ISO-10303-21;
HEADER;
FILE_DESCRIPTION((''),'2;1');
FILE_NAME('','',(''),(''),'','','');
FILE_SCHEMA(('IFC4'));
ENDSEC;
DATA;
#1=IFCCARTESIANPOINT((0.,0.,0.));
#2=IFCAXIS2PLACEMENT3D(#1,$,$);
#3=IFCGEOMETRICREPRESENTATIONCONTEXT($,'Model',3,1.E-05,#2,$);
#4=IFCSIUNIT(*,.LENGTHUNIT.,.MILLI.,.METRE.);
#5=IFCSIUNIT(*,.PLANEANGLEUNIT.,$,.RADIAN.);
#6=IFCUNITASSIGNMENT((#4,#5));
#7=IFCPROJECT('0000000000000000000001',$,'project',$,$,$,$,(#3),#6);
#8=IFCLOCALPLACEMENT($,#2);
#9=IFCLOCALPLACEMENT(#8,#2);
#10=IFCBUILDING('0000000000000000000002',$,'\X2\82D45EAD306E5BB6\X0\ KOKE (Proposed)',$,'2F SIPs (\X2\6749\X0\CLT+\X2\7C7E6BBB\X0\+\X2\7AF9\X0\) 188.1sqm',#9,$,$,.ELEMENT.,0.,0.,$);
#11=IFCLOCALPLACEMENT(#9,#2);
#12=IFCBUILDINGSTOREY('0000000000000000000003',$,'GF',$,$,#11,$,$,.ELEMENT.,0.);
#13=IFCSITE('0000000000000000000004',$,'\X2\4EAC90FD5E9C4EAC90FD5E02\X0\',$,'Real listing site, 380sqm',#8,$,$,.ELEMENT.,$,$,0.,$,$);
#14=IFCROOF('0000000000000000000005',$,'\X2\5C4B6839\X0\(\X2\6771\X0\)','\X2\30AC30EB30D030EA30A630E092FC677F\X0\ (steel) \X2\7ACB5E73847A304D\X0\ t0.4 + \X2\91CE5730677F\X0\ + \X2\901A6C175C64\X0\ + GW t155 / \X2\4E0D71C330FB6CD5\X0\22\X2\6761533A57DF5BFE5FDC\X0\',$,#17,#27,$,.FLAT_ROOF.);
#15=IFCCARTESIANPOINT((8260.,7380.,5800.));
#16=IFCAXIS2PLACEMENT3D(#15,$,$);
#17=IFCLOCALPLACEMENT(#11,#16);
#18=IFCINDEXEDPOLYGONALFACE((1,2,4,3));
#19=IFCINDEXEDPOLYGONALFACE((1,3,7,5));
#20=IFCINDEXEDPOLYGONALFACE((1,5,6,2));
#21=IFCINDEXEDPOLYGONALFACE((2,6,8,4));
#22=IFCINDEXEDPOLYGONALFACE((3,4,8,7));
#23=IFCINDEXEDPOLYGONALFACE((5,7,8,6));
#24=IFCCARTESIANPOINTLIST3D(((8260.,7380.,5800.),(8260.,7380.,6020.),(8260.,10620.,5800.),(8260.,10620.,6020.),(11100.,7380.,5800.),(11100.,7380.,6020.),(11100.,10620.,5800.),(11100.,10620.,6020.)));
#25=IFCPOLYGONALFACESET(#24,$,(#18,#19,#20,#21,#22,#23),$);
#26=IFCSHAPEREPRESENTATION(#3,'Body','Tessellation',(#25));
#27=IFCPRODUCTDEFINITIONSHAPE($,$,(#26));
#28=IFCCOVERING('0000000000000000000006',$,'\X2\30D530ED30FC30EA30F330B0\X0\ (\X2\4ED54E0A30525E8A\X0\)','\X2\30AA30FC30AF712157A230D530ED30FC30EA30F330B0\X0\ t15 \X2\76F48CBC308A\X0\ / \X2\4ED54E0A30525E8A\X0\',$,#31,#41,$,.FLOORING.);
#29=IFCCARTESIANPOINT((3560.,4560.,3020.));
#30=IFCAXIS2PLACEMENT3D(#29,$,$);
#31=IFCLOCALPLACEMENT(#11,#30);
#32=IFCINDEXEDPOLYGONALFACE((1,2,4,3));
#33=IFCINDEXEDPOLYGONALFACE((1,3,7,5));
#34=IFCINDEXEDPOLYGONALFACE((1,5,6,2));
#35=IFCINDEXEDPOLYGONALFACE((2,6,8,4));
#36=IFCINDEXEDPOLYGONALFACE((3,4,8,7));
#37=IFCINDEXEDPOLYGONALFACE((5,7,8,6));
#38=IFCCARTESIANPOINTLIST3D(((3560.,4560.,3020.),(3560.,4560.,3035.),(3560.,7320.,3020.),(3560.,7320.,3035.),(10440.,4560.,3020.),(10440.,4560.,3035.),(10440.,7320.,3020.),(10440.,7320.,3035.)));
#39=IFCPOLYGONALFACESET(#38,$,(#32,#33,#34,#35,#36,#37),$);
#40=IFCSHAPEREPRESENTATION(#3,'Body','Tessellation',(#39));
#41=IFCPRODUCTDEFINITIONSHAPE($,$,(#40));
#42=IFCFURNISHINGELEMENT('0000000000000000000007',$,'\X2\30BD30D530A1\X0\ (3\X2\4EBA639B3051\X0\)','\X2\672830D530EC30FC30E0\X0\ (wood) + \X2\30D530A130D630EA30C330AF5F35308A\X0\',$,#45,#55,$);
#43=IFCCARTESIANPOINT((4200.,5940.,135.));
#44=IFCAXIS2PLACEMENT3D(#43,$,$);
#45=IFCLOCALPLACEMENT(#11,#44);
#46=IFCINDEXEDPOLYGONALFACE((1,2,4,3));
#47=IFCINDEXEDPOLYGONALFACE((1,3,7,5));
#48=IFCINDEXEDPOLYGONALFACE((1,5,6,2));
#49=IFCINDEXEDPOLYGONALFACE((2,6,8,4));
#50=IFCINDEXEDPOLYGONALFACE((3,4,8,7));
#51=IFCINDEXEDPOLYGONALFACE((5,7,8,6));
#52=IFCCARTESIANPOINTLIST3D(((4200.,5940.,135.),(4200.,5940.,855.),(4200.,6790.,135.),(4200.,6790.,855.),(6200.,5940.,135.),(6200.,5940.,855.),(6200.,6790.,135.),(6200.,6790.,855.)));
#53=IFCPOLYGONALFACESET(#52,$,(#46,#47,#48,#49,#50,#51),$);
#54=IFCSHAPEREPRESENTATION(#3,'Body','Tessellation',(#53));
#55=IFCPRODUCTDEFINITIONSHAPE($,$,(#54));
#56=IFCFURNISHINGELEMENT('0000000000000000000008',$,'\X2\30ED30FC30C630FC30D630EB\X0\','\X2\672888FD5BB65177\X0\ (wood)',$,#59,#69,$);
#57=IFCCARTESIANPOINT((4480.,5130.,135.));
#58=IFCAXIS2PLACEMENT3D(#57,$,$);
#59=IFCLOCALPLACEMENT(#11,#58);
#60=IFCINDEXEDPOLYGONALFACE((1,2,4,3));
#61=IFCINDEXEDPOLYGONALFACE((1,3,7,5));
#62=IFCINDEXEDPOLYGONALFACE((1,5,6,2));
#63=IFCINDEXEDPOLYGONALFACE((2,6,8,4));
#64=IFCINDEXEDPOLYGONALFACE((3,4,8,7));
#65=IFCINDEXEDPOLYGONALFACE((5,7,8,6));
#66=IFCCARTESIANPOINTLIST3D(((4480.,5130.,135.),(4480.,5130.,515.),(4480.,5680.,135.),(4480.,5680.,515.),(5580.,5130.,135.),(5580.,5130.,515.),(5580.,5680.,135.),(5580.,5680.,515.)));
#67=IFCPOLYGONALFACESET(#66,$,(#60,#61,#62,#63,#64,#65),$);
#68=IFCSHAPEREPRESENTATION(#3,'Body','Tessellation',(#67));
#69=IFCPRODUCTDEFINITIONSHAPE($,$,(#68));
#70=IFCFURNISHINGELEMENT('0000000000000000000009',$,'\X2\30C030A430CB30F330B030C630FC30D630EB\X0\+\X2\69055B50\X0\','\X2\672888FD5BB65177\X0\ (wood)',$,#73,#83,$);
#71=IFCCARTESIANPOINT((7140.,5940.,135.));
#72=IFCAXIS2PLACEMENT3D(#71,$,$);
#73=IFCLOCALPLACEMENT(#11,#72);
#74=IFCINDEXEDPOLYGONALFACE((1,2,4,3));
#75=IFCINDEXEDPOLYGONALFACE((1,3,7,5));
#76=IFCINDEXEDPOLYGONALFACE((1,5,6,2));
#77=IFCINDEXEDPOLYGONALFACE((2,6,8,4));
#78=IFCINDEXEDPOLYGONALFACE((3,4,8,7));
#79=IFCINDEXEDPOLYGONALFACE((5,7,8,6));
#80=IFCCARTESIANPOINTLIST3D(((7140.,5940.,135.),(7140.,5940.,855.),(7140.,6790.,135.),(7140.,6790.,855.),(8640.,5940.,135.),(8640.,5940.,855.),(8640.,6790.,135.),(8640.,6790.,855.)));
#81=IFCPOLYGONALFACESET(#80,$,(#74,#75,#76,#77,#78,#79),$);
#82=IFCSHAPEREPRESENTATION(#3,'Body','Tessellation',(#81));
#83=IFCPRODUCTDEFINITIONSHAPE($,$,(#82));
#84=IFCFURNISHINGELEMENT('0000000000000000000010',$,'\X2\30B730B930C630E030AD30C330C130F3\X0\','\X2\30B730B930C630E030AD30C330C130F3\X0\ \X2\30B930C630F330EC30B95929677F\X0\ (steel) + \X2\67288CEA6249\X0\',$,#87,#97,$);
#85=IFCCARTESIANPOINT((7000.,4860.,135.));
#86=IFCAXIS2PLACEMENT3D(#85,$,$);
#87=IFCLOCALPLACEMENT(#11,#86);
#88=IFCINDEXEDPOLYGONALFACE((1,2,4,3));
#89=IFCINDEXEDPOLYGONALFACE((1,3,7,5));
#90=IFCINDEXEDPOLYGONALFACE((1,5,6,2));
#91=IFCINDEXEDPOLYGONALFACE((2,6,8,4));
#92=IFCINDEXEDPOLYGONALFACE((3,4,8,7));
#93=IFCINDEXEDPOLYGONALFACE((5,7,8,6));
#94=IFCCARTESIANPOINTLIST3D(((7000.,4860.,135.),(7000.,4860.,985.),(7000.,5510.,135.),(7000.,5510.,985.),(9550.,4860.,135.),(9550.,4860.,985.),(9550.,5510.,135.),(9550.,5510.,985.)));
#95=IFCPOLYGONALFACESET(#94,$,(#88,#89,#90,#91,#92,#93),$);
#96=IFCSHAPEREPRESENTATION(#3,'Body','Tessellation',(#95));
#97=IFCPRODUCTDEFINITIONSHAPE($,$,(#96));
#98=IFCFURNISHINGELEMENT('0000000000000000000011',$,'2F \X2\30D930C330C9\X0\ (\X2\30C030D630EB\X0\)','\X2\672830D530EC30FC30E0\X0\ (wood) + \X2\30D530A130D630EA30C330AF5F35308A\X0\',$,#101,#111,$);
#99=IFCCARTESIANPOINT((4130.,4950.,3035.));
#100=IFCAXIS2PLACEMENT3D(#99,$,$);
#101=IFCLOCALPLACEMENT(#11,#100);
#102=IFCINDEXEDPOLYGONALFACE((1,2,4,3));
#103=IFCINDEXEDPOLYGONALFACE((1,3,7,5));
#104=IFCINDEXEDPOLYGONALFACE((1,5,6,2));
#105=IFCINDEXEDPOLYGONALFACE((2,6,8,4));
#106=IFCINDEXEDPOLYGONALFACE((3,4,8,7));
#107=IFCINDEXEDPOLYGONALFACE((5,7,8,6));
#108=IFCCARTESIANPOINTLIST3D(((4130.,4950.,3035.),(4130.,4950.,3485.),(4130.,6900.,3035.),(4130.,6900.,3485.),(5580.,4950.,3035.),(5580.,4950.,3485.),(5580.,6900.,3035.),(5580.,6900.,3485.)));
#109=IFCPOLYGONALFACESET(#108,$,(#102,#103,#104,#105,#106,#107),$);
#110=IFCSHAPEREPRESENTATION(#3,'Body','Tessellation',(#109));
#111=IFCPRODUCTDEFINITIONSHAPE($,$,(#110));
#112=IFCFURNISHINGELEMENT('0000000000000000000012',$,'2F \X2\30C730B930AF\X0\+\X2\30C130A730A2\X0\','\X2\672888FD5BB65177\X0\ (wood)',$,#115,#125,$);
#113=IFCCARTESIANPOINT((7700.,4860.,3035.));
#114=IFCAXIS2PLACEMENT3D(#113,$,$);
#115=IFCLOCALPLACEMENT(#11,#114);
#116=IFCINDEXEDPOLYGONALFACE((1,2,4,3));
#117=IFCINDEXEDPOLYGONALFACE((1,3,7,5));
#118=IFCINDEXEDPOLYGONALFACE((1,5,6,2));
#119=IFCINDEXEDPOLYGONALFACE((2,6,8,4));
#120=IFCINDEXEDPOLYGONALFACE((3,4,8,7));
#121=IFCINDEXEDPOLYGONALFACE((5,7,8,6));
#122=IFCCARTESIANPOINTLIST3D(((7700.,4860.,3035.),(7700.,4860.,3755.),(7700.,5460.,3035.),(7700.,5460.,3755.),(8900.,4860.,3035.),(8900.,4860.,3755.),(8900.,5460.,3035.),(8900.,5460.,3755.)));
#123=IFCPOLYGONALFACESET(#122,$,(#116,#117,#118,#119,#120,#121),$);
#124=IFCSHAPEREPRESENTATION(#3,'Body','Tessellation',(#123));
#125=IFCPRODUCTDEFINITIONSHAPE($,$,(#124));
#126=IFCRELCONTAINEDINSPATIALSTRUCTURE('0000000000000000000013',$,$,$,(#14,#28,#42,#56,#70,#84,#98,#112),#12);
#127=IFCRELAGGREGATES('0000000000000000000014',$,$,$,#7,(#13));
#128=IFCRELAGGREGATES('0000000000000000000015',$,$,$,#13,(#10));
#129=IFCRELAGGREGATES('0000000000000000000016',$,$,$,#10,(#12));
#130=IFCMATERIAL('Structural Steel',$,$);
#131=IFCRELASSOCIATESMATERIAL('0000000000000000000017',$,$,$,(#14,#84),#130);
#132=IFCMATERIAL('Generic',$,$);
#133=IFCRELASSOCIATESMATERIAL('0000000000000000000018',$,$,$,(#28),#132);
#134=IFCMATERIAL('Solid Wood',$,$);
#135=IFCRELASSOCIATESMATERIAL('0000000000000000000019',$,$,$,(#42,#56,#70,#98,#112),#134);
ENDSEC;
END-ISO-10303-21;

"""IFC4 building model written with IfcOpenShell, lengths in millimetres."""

from ifc_helpers import new_model, si_unit, frame, frame_2d, origin, place, context, project, spatial, rectangle, extrude, material, element, save


model = new_model("IFC4")

# Units and contexts
model_context = context("Model", 3, precision=1e-05, world=origin())
ifc_project = project(units=[si_unit("LENGTHUNIT", "METRE", prefix="MILLI"), si_unit("PLANEANGLEUNIT", "RADIAN")], contexts=[model_context])

# Site, building, storey
site_placement = place(None, origin())
site = spatial("IfcSite", under=ifc_project, at=site_placement, Name="京都府京都市", ObjectType="Real listing site, 380sqm", CompositionType="ELEMENT", RefElevation=0.0)
building_placement = place(site_placement, origin())
building = spatial("IfcBuilding", under=site, at=building_placement, Name="苔庭の家 KOKE (Proposed)", ObjectType="2F SIPs (杉CLT+籾殻+竹) 188.1sqm", CompositionType="ELEMENT", ElevationOfRefHeight=0.0, ElevationOfTerrain=0.0)
storey_placement = place(building_placement, origin())
storey = spatial("IfcBuildingStorey", under=building, at=storey_placement, Name="GF", CompositionType="ELEMENT", Elevation=0.0)

# Shared definitions
ifc_material_1 = material(Name="Solid Wood")

# Shared definitions
ifc_material_2 = material(Name="Generic")

# Roof
ifc_material_3 = material(Name="Structural Steel")
roof_placement = place(storey_placement, frame((8260.0, 7380.0, 5800.0)))
element("IfcRoof", 1, at=roof_placement, inside=storey, material=ifc_material_3, Name="屋根(東)", Description="ガルバリウム鋼板 (steel) 立平葺き t0.4 + 野地板 + 通気層 + GW t155 / 不燃・法22条区域対応", PredefinedType="FLAT_ROOF", context=model_context, shape_type="SweptSolid", body=[
    extrude(rectangle(XDim=2840.0, YDim=3240.0, at=frame_2d((1420.0, 1620.0))), frame((8260.0, 7380.0, 5800.0)), (0.0, 0.0, 1.0), 220.0),
])

# Covering
covering_placement = place(storey_placement, frame((3560.0, 4560.0, 3020.0)))
element("IfcCovering", 2, at=covering_placement, inside=storey, material=ifc_material_2, Name="フローリング (仕上げ床)", Description="オーク無垢フローリング t15 直貼り / 仕上げ床", PredefinedType="FLOORING", context=model_context, shape_type="SweptSolid", body=[
    extrude(rectangle(XDim=6880.0, YDim=2760.0, at=frame_2d((3440.0, 1380.0))), frame((3560.0, 4560.0, 3020.0)), (0.0, 0.0, 1.0), 15.0),
])

# Furnishing elements
furnishing_1_placement = place(storey_placement, frame((4200.0, 5940.0, 135.0)))
element("IfcFurnishingElement", 3, at=furnishing_1_placement, inside=storey, material=ifc_material_1, Name="ソファ (3人掛け)", Description="木フレーム (wood) + ファブリック張り", context=model_context, shape_type="SweptSolid", body=[
    extrude(rectangle(XDim=2000.0, YDim=850.0, at=frame_2d((1000.0, 425.0))), frame((4200.0, 5940.0, 135.0)), (0.0, 0.0, 1.0), 720.0),
])
furnishing_2_placement = place(storey_placement, frame((4480.0, 5130.0, 135.0)))
element("IfcFurnishingElement", 4, at=furnishing_2_placement, inside=storey, material=ifc_material_1, Name="ローテーブル", Description="木製家具 (wood)", context=model_context, shape_type="SweptSolid", body=[
    extrude(rectangle(XDim=1100.0, YDim=550.0, at=frame_2d((550.0, 275.0))), frame((4480.0, 5130.0, 135.0)), (0.0, 0.0, 1.0), 380.0),
])
furnishing_3_placement = place(storey_placement, frame((7140.0, 5940.0, 135.0)))
element("IfcFurnishingElement", 5, at=furnishing_3_placement, inside=storey, material=ifc_material_1, Name="ダイニングテーブル+椅子", Description="木製家具 (wood)", context=model_context, shape_type="SweptSolid", body=[
    extrude(rectangle(XDim=1500.0, YDim=850.0, at=frame_2d((750.0, 425.0))), frame((7140.0, 5940.0, 135.0)), (0.0, 0.0, 1.0), 720.0),
])
furnishing_4_placement = place(storey_placement, frame((7000.0, 4860.0, 135.0)))
element("IfcFurnishingElement", 6, at=furnishing_4_placement, inside=storey, material=ifc_material_3, Name="システムキッチン", Description="システムキッチン ステンレス天板 (steel) + 木質扉", context=model_context, shape_type="SweptSolid", body=[
    extrude(rectangle(XDim=2550.0, YDim=650.0, at=frame_2d((1275.0, 325.0))), frame((7000.0, 4860.0, 135.0)), (0.0, 0.0, 1.0), 850.0),
])
furnishing_5_placement = place(storey_placement, frame((4130.0, 4950.0, 3035.0)))
element("IfcFurnishingElement", 7, at=furnishing_5_placement, inside=storey, material=ifc_material_1, Name="2F ベッド (ダブル)", Description="木フレーム (wood) + ファブリック張り", context=model_context, shape_type="SweptSolid", body=[
    extrude(rectangle(XDim=1450.0, YDim=1950.0, at=frame_2d((725.0, 975.0))), frame((4130.0, 4950.0, 3035.0)), (0.0, 0.0, 1.0), 450.0),
])
furnishing_6_placement = place(storey_placement, frame((7700.0, 4860.0, 3035.0)))
element("IfcFurnishingElement", 8, at=furnishing_6_placement, inside=storey, material=ifc_material_1, Name="2F デスク+チェア", Description="木製家具 (wood)", context=model_context, shape_type="SweptSolid", body=[
    extrude(rectangle(XDim=1200.0, YDim=600.0, at=frame_2d((600.0, 300.0))), frame((7700.0, 4860.0, 3035.0)), (0.0, 0.0, 1.0), 720.0),
])

save(model, "model.ifc")
